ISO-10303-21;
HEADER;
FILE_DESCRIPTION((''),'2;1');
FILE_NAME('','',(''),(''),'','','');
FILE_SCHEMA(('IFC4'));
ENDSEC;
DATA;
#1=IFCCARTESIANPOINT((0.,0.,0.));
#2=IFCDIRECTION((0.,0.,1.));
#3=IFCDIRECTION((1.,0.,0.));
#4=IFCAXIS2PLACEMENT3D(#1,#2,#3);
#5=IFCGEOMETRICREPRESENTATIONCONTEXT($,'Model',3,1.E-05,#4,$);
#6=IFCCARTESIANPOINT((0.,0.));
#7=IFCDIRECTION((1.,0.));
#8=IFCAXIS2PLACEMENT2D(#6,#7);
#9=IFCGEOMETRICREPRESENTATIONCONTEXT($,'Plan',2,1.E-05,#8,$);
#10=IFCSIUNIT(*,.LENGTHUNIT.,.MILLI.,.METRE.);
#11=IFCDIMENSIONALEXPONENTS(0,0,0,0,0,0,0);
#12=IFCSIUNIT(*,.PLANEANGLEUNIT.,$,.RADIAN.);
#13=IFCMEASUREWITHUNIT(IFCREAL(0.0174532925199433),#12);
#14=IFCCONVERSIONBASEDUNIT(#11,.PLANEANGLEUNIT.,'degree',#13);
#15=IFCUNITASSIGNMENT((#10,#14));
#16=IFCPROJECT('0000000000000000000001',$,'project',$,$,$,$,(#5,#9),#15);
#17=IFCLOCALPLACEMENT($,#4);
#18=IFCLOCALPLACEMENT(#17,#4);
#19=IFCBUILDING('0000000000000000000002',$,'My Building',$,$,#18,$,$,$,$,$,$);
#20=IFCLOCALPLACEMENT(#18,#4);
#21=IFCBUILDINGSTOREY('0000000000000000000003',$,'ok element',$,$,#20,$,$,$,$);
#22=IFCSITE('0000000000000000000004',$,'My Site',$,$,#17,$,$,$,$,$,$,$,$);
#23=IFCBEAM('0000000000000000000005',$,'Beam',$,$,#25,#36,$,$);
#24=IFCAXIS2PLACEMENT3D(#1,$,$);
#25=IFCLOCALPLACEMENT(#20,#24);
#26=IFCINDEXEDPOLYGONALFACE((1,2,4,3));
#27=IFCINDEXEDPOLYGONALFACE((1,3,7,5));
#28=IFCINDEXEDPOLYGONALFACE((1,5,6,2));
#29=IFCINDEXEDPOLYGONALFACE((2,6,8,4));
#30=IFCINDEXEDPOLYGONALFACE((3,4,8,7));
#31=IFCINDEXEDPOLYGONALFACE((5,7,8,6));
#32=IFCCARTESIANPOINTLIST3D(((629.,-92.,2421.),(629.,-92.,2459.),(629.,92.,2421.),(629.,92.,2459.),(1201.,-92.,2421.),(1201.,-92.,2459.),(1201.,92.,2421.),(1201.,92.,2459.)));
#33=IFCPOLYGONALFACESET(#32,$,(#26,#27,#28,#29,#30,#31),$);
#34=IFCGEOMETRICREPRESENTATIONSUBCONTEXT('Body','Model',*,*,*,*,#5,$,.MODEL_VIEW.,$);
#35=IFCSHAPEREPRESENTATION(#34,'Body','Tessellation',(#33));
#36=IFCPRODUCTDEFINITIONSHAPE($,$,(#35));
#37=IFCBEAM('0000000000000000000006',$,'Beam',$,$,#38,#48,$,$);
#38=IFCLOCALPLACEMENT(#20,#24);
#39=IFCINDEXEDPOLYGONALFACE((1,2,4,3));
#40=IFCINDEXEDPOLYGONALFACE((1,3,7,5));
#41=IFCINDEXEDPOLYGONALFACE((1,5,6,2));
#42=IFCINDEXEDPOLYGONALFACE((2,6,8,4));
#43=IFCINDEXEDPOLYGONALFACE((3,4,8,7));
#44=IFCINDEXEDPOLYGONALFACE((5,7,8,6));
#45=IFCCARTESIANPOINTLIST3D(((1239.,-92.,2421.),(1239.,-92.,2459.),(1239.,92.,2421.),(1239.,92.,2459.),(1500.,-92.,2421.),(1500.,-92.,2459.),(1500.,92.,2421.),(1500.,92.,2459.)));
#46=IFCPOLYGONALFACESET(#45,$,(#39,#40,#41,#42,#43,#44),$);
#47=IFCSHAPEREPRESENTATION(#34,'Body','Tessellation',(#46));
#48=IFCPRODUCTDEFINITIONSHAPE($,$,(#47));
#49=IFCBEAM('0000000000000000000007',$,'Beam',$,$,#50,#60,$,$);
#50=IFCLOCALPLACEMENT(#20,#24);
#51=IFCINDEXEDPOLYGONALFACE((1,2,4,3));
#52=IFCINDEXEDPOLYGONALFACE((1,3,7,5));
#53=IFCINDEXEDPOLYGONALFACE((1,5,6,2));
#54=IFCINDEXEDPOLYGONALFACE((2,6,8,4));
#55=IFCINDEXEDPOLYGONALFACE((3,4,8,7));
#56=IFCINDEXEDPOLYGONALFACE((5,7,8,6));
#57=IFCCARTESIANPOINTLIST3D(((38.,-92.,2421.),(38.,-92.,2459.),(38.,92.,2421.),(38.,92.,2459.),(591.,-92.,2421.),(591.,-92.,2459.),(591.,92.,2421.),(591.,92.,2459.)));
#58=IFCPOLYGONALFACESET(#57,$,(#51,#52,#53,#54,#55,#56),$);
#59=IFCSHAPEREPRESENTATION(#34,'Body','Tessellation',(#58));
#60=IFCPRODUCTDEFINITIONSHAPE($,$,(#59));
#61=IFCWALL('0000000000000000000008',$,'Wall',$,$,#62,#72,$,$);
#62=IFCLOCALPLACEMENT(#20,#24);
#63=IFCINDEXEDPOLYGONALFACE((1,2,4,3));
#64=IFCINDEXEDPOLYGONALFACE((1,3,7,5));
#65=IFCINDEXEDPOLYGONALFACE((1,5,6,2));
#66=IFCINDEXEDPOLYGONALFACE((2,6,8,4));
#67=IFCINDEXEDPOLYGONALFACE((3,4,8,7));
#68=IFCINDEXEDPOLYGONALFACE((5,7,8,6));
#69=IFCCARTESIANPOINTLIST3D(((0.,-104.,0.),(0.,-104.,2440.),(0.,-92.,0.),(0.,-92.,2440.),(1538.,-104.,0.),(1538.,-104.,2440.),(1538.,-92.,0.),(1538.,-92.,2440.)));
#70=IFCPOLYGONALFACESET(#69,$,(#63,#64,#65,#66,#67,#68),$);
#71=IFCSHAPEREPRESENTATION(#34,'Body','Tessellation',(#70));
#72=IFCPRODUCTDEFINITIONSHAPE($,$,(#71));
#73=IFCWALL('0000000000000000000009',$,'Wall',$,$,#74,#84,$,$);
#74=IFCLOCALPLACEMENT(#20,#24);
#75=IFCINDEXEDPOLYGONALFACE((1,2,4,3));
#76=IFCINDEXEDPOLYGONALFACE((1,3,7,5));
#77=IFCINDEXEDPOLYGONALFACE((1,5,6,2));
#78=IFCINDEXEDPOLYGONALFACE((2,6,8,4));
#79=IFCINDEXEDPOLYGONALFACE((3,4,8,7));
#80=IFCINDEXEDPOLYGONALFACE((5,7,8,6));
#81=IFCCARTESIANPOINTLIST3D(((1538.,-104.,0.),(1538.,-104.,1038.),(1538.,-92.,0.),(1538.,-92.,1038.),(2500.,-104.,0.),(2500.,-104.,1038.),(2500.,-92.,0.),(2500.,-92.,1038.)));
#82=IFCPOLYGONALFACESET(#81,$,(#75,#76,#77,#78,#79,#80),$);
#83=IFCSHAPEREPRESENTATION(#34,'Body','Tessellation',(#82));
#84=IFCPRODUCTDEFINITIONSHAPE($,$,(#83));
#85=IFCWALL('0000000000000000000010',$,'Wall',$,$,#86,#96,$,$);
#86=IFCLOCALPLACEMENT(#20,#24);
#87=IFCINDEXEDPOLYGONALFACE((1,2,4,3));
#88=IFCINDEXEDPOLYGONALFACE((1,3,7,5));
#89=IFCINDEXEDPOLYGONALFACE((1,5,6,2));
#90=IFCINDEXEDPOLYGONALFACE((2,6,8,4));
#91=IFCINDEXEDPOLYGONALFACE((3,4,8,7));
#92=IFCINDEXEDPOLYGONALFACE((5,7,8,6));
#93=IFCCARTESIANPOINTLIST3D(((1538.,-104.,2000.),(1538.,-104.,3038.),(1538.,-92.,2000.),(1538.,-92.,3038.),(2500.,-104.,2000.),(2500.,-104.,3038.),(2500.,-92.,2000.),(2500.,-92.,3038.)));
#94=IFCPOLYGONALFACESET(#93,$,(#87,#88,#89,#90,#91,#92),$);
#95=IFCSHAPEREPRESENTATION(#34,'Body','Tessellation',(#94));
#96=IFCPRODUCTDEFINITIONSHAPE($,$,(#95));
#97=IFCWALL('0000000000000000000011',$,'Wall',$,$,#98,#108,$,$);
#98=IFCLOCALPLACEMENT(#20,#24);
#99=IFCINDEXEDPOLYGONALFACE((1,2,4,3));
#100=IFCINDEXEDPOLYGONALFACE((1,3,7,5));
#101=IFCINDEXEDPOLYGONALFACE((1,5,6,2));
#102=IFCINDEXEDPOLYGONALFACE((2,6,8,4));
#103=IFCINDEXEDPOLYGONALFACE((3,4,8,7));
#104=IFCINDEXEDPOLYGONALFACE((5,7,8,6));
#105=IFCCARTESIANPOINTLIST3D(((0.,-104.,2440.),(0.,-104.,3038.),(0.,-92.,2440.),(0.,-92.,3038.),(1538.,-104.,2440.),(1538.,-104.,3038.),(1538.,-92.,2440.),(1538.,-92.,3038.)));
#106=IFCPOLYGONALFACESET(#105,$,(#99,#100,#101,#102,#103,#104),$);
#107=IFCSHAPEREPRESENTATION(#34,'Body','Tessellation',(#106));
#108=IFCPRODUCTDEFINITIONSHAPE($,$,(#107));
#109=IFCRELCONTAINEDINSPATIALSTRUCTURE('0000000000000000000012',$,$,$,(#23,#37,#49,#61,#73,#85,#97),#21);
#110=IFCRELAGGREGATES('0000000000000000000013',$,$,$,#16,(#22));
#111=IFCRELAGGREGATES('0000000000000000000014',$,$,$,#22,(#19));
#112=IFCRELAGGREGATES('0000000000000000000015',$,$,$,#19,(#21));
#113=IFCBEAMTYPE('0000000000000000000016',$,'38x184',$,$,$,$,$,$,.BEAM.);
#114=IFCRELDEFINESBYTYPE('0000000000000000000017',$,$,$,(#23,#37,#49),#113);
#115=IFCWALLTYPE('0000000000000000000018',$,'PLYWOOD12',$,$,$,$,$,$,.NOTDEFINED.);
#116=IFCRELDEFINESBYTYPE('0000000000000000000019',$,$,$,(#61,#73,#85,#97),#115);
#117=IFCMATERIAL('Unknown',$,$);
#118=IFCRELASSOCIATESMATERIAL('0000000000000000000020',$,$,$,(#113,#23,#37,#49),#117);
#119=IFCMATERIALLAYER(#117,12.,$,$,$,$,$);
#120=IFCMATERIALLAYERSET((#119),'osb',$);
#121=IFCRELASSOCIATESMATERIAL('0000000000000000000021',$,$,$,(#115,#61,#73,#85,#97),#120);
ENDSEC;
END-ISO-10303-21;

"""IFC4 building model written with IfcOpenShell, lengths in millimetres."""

from ifc_helpers import new_model, entity, si_unit, converted_unit, frame, origin_with_axes, origin_2d_with_axis, place, context, subcontext, project, spatial, indexed_curve, rectangle, outline, extrude, material, layer, layer_set, layer_usage, material_profile, profile_set, profile_usage, type_object, element, save


model = new_model("IFC4")

# Units and contexts
model_context = context("Model", 3, precision=1e-05, world=origin_with_axes())
plan_context = context("Plan", 2, precision=1e-05, world=origin_2d_with_axis())
body_context = subcontext(model_context, "Body", "Model", "MODEL_VIEW")
ifc_project = project(units=[si_unit("LENGTHUNIT", "METRE", prefix="MILLI"), converted_unit("PLANEANGLEUNIT", "degree", entity("IfcReal", 0.0174532925199433), si_unit("PLANEANGLEUNIT", "RADIAN"), dimensions=[0, 0, 0, 0, 0, 0, 0])], contexts=[model_context, plan_context])

# Site, building, storey
site_placement = place(None, origin_with_axes())
site = spatial("IfcSite", under=ifc_project, at=site_placement, Name="My Site")
building_placement = place(site_placement, origin_with_axes())
building = spatial("IfcBuilding", under=site, at=building_placement, Name="My Building")
storey_placement = place(building_placement, origin_with_axes())
storey = spatial("IfcBuildingStorey", under=building, at=storey_placement, Name="ok element")

# Beams
ifc_material = material(Name="Unknown")
ifc_material_profile = material_profile(ifc_material, rectangle(XDim=184.0, YDim=38.0))
ifc_profile_set = profile_set([ifc_material_profile], Name="vurenhout")
beam_type = type_object("IfcBeamType", Name="38x184", PredefinedType="BEAM", material=ifc_profile_set)
ifc_profile_usage_1 = profile_usage(ifc_profile_set, cardinal=2)
beam_1_placement = place(storey_placement, frame((629.0, 0.0, 2421.0), z_axis=(1.0, 0.0, 0.0), x_axis=(0.0, 1.0, 0.0)))
element("IfcBeam", 1, at=beam_1_placement, inside=storey, type_object=beam_type, material=ifc_profile_usage_1, Name="Beam", context=body_context, shape_type="SweptSolid", body=[
    extrude(rectangle(XDim=184.0, YDim=38.0), frame((0.0, 19.0, 0.0), z_axis=(0.0, 0.0, 1.0), x_axis=(1.0, 0.0, 0.0)), (0.0, 0.0, 1.0), 572.0),
])
ifc_profile_usage_2 = profile_usage(ifc_profile_set, cardinal=2)
beam_2_placement = place(storey_placement, frame((1239.0, 0.0, 2421.0), z_axis=(1.0, 0.0, 0.0), x_axis=(0.0, 1.0, 0.0)))
element("IfcBeam", 2, at=beam_2_placement, inside=storey, type_object=beam_type, material=ifc_profile_usage_2, Name="Beam", context=body_context, shape_type="SweptSolid", body=[
    extrude(rectangle(XDim=184.0, YDim=38.0), frame((0.0, 19.0, 0.0), z_axis=(0.0, 0.0, 1.0), x_axis=(1.0, 0.0, 0.0)), (0.0, 0.0, 1.0), 261.0),
])
ifc_profile_usage_3 = profile_usage(ifc_profile_set, cardinal=2)
beam_3_placement = place(storey_placement, frame((38.0, 0.0, 2421.0), z_axis=(1.0, 0.0, 0.0), x_axis=(0.0, 1.0, 0.0)))
element("IfcBeam", 3, at=beam_3_placement, inside=storey, type_object=beam_type, material=ifc_profile_usage_3, Name="Beam", context=body_context, shape_type="SweptSolid", body=[
    extrude(rectangle(XDim=184.0, YDim=38.0), frame((0.0, 19.0, 0.0), z_axis=(0.0, 0.0, 1.0), x_axis=(1.0, 0.0, 0.0)), (0.0, 0.0, 1.0), 553.0),
])

# Walls
ifc_layer = layer(ifc_material, 12.0)
ifc_layer_set = layer_set([ifc_layer], Name="osb")
ifc_layer_usage_1 = layer_usage(ifc_layer_set, "AXIS2", "POSITIVE", 0.0)
wall_type = type_object("IfcWallType", Name="PLYWOOD12", PredefinedType="NOTDEFINED", material=ifc_layer_set)
wall_1_placement = place(storey_placement, frame((0.0, -104.0, 0.0), z_axis=(0.0, 0.0, 1.0), x_axis=(1.0, 0.0, 0.0)))
element("IfcWall", 4, at=wall_1_placement, inside=storey, type_object=wall_type, material=ifc_layer_usage_1, Name="Wall", context=body_context, shape_type="SweptSolid", body=[
    extrude(outline(indexed_curve([(0.0, 0.0), (0.0, 12.0), (1538.0, 12.0), (1538.0, 0.0), (0.0, 0.0)], self_intersect=False)), origin_with_axes(), (0.0, 0.0, 1.0), 2440.0),
])
ifc_layer_usage_2 = layer_usage(ifc_layer_set, "AXIS2", "POSITIVE", 0.0)
wall_2_placement = place(storey_placement, frame((1538.0, -104.0, 0.0), z_axis=(0.0, 0.0, 1.0), x_axis=(1.0, 0.0, 0.0)))
element("IfcWall", 5, at=wall_2_placement, inside=storey, type_object=wall_type, material=ifc_layer_usage_2, Name="Wall", context=body_context, shape_type="SweptSolid", body=[
    extrude(outline(indexed_curve([(0.0, 0.0), (0.0, 12.0), (962.0, 12.0), (962.0, 0.0), (0.0, 0.0)], self_intersect=False)), origin_with_axes(), (0.0, 0.0, 1.0), 1038.0),
])
ifc_layer_usage_3 = layer_usage(ifc_layer_set, "AXIS2", "POSITIVE", 0.0)
wall_3_placement = place(storey_placement, frame((1538.0, -104.0, 2000.0), z_axis=(0.0, 0.0, 1.0), x_axis=(1.0, 0.0, 0.0)))
element("IfcWall", 6, at=wall_3_placement, inside=storey, type_object=wall_type, material=ifc_layer_usage_3, Name="Wall", context=body_context, shape_type="SweptSolid", body=[
    extrude(outline(indexed_curve([(0.0, 0.0), (0.0, 12.0), (962.0, 12.0), (962.0, 0.0), (0.0, 0.0)], self_intersect=False)), origin_with_axes(), (0.0, 0.0, 1.0), 1038.0),
])
ifc_layer_usage_4 = layer_usage(ifc_layer_set, "AXIS2", "POSITIVE", 0.0)
wall_4_placement = place(storey_placement, frame((0.0, -104.0, 2440.0), z_axis=(0.0, 0.0, 1.0), x_axis=(1.0, 0.0, 0.0)))
element("IfcWall", 7, at=wall_4_placement, inside=storey, type_object=wall_type, material=ifc_layer_usage_4, Name="Wall", context=body_context, shape_type="SweptSolid", body=[
    extrude(outline(indexed_curve([(0.0, 0.0), (0.0, 12.0), (1538.0, 12.0), (1538.0, 0.0), (0.0, 0.0)], self_intersect=False)), origin_with_axes(), (0.0, 0.0, 1.0), 598.0),
])

save(model, "model.ifc")
